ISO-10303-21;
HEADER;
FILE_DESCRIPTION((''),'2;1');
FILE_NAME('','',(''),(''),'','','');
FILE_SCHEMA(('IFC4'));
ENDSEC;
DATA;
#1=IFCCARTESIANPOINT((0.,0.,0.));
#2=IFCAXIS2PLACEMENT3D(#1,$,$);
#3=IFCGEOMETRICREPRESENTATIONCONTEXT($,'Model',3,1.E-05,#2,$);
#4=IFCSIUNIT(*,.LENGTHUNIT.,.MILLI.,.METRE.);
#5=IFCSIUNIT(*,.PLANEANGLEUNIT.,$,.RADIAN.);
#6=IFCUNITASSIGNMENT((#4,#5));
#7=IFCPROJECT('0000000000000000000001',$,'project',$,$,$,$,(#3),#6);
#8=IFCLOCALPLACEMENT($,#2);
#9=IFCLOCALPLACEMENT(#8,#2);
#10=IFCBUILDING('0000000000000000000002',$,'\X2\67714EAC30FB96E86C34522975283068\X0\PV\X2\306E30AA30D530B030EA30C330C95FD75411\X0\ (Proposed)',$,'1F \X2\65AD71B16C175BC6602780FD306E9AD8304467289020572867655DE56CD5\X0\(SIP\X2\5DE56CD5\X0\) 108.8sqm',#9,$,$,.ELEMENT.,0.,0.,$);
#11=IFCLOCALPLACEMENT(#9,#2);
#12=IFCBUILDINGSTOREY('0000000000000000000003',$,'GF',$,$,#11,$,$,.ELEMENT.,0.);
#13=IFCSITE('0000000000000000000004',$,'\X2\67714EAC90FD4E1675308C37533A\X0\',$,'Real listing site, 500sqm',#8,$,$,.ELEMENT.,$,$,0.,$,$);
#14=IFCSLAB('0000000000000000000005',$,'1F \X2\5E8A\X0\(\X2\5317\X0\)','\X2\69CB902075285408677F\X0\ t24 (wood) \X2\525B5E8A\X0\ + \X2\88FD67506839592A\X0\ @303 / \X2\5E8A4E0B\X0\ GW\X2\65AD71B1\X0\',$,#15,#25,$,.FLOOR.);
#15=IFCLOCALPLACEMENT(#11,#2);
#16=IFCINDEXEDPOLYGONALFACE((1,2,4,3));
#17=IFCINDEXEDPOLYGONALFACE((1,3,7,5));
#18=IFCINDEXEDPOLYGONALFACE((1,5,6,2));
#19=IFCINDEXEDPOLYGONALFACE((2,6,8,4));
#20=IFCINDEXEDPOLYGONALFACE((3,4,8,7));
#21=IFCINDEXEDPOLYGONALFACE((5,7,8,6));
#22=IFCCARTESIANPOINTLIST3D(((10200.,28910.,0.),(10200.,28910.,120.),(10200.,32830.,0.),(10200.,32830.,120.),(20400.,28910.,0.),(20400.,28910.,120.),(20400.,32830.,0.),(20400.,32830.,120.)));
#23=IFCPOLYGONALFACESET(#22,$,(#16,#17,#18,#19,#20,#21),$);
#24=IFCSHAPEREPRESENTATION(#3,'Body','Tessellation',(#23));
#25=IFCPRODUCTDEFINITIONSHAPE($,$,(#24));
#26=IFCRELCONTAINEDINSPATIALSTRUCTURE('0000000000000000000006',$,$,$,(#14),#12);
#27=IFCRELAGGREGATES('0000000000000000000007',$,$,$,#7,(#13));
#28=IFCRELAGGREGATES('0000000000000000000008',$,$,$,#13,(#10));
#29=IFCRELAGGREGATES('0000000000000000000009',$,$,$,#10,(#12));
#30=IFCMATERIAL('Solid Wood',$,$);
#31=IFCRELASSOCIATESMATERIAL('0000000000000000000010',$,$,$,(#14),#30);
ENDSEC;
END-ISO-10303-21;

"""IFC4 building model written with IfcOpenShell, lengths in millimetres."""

from ifc_helpers import new_model, si_unit, frame, frame_2d, origin, place, context, project, spatial, rectangle, extrude, material, element, save


model = new_model("IFC4")

# Units and contexts
model_context = context("Model", 3, precision=1e-05, world=origin())
ifc_project = project(units=[si_unit("LENGTHUNIT", "METRE", prefix="MILLI"), si_unit("PLANEANGLEUNIT", "RADIAN")], contexts=[model_context])

# Site, building, storey
site_placement = place(None, origin())
site = spatial("IfcSite", under=ifc_project, at=site_placement, Name="東京都世田谷区", ObjectType="Real listing site, 500sqm", CompositionType="ELEMENT", RefElevation=0.0)
building_placement = place(site_placement, origin())
building = spatial("IfcBuilding", under=site, at=building_placement, Name="東京・雨水利用とPVのオフグリッド志向 (Proposed)", ObjectType="1F 断熱気密性能の高い木造在来工法(SIP工法) 108.8sqm", CompositionType="ELEMENT", ElevationOfRefHeight=0.0, ElevationOfTerrain=0.0)
storey_placement = place(building_placement, origin())
storey = spatial("IfcBuildingStorey", under=building, at=storey_placement, Name="GF", CompositionType="ELEMENT", Elevation=0.0)

# Shared definitions
ifc_material_1 = material(Name="Solid Wood")

# Slab
slab_placement = place(storey_placement, frame((5100.0, 14455.0, 0.0)))
element("IfcSlab", 1, at=slab_placement, inside=storey, material=ifc_material_1, Name="1F 床(北)", Description="構造用合板 t24 (wood) 剛床 + 製材根太 @303 / 床下 GW断熱", PredefinedType="FLOOR", context=model_context, shape_type="SweptSolid", body=[
    extrude(rectangle(XDim=10200.0, YDim=3920.0, at=frame_2d((5100.0, 1960.0))), frame((5100.0, 14455.0, 0.0)), (0.0, 0.0, 1.0), 120.0),
])

save(model, "model.ifc")
